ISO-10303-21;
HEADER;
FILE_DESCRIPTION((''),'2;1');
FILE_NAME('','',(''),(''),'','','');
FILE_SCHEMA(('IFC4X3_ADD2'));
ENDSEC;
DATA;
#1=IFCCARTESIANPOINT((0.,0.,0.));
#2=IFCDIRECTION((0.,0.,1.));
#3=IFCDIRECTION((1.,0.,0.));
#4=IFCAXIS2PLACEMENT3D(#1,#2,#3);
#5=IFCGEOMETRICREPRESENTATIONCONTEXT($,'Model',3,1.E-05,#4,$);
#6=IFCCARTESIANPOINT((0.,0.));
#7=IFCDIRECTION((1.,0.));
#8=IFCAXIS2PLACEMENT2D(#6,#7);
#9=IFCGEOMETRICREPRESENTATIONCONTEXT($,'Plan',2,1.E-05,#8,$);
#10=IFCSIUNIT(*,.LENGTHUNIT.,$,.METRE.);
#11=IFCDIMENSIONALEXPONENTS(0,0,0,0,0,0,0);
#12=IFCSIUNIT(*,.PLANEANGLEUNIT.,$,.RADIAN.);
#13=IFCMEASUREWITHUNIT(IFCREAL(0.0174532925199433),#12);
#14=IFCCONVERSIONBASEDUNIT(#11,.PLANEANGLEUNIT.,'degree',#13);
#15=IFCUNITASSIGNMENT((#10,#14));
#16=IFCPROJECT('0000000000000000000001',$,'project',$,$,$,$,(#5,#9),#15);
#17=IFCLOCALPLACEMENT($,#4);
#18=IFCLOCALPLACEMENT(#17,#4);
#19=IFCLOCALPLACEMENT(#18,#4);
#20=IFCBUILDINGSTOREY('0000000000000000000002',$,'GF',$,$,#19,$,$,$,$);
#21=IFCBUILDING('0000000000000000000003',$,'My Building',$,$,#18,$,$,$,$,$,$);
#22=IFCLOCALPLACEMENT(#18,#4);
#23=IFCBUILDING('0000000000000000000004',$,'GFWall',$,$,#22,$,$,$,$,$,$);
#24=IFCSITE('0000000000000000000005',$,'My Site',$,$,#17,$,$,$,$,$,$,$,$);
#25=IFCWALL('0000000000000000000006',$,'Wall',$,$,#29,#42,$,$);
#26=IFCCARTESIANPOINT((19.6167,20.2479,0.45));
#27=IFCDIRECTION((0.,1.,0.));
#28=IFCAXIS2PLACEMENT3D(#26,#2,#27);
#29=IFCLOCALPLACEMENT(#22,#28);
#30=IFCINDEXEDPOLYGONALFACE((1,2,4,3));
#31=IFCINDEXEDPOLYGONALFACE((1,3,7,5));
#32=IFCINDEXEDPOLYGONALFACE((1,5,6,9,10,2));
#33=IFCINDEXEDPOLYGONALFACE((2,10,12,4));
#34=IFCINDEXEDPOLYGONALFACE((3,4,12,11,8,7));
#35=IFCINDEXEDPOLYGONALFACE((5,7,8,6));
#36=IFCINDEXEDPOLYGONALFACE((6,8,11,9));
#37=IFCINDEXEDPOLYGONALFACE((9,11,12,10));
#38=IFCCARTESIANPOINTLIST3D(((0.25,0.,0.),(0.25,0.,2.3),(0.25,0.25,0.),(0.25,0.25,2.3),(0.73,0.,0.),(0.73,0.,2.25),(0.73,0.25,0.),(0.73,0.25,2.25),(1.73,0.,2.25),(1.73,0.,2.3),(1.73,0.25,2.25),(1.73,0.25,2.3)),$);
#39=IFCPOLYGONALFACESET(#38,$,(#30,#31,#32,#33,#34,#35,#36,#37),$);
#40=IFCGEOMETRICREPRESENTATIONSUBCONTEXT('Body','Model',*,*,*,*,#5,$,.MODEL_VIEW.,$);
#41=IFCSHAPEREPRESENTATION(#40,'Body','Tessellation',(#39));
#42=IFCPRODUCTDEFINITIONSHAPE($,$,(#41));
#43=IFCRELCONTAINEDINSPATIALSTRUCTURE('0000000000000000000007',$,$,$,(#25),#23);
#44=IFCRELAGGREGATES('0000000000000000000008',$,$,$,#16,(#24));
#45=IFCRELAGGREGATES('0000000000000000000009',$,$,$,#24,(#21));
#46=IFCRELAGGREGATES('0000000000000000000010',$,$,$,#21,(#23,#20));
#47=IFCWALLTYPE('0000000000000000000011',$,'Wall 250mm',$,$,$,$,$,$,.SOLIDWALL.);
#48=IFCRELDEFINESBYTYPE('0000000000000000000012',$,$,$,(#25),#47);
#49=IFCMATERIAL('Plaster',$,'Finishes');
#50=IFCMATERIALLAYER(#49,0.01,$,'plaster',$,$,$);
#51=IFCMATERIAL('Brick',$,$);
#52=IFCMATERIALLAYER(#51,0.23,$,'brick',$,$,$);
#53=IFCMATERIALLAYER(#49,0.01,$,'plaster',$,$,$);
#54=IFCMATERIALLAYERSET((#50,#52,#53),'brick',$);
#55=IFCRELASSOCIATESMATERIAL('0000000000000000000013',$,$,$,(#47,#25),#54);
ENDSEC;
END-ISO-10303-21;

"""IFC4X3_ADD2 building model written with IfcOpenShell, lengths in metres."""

from ifc_helpers import new_model, entity, si_unit, converted_unit, frame, origin_with_axes, origin_2d_with_axis, place, context, subcontext, project, spatial, line, indexed_curve, outline, extrude, source, transform, mapped, material, layer, layer_set, layer_usage, type_object, element, save


model = new_model("IFC4X3_ADD2")

# Units and contexts
model_context = context("Model", 3, precision=1e-05, world=origin_with_axes())
plan_context = context("Plan", 2, precision=1e-05, world=origin_2d_with_axis())
body_context_1 = subcontext(model_context, "Body", "Model", "MODEL_VIEW")
ifc_project = project(units=[si_unit("LENGTHUNIT", "METRE"), converted_unit("PLANEANGLEUNIT", "degree", entity("IfcReal", 0.0174532925199433), si_unit("PLANEANGLEUNIT", "RADIAN"), dimensions=[0, 0, 0, 0, 0, 0, 0])], contexts=[model_context, plan_context])

# Site, buildings
site_placement = place(None, origin_with_axes())
site = spatial("IfcSite", under=ifc_project, at=site_placement, Name="My Site")
building_1_placement = place(site_placement, origin_with_axes())
building_1 = spatial("IfcBuilding", under=site, at=building_1_placement, Name="My Building")
building_2_placement = place(building_1_placement, origin_with_axes())
building_2 = spatial("IfcBuilding", under=building_1, at=building_2_placement, Name="GFWall")

# Shared definitions
ifc_material_1 = material(Name="Plaster", Category="Finishes")
ifc_material_2 = material(Name="Brick")

# Shared definitions
ifc_layer_1 = layer(ifc_material_1, 0.01, Name="plaster")
ifc_layer_2 = layer(ifc_material_2, 0.23, Name="brick")
ifc_layer_3 = layer(ifc_material_1, 0.01, Name="plaster")
ifc_layer_set_1 = layer_set([ifc_layer_1, ifc_layer_2, ifc_layer_3], Name="brick")
wall_type_1 = type_object("IfcWallType", Name="Wall 250mm", PredefinedType="SOLIDWALL", material=ifc_layer_set_1)

# Shared definitions
storey_placement = place(building_1_placement, origin_with_axes())
storey = spatial("IfcBuildingStorey", under=building_1, at=storey_placement, Name="GF")

# Wall, opening
ifc_layer_usage_1 = layer_usage(ifc_layer_set_1, "AXIS2", "POSITIVE", 0.0)
wall_1_placement = place(building_2_placement, frame((19.6167, 20.2479, 0.45), z_axis=(0.0, 0.0, 1.0), x_axis=(0.0, 1.0, 0.0)))
wall_1 = element("IfcWall", 1, at=wall_1_placement, inside=building_2, type_object=wall_type_1, material=ifc_layer_usage_1, Name="Wall", context=body_context_1, shape_type="SweptSolid", body=[
    extrude(outline(indexed_curve([(0.25, 0.0), (0.25, 0.25), (1.73, 0.25), (1.73, 0.0)], segments=[line(1, 2, 3, 4, 1)])), origin_with_axes(), (0.0, 0.0, 1.0), 2.3),
])
shared_shape_1 = source(origin_with_axes(), body_context_1, "Body", "SweptSolid", [
    extrude(outline(indexed_curve([(0.0, 2.25), (1.0, 2.25), (1.0, 0.0), (0.0, 0.0), (0.0, 2.25)])), frame((0.0, -0.6, 0.0), z_axis=(0.0, -1.0, 0.0), x_axis=(1.0, 0.0, 0.0)), (0.0, 0.0, -1.0), 1.2),
])
opening_1_placement = place(wall_1_placement, frame((1.73, 0.1071, 0.0), z_axis=(0.0, 0.0, 1.0), x_axis=(-1.0, 0.0, 0.0)))
element("IfcOpeningElement", 2, at=opening_1_placement, cuts=wall_1, PredefinedType="OPENING", context=body_context_1, shape_type="MappedRepresentation", body=[
    mapped(shared_shape_1, transform((0.0, 0.0, 0.0), x_axis=(1.0, 0.0, 0.0), y_axis=(0.0, 1.0, 0.0), z_axis=(0.0, 0.0, 1.0), scale=1.0)),
])

save(model, "model.ifc")
